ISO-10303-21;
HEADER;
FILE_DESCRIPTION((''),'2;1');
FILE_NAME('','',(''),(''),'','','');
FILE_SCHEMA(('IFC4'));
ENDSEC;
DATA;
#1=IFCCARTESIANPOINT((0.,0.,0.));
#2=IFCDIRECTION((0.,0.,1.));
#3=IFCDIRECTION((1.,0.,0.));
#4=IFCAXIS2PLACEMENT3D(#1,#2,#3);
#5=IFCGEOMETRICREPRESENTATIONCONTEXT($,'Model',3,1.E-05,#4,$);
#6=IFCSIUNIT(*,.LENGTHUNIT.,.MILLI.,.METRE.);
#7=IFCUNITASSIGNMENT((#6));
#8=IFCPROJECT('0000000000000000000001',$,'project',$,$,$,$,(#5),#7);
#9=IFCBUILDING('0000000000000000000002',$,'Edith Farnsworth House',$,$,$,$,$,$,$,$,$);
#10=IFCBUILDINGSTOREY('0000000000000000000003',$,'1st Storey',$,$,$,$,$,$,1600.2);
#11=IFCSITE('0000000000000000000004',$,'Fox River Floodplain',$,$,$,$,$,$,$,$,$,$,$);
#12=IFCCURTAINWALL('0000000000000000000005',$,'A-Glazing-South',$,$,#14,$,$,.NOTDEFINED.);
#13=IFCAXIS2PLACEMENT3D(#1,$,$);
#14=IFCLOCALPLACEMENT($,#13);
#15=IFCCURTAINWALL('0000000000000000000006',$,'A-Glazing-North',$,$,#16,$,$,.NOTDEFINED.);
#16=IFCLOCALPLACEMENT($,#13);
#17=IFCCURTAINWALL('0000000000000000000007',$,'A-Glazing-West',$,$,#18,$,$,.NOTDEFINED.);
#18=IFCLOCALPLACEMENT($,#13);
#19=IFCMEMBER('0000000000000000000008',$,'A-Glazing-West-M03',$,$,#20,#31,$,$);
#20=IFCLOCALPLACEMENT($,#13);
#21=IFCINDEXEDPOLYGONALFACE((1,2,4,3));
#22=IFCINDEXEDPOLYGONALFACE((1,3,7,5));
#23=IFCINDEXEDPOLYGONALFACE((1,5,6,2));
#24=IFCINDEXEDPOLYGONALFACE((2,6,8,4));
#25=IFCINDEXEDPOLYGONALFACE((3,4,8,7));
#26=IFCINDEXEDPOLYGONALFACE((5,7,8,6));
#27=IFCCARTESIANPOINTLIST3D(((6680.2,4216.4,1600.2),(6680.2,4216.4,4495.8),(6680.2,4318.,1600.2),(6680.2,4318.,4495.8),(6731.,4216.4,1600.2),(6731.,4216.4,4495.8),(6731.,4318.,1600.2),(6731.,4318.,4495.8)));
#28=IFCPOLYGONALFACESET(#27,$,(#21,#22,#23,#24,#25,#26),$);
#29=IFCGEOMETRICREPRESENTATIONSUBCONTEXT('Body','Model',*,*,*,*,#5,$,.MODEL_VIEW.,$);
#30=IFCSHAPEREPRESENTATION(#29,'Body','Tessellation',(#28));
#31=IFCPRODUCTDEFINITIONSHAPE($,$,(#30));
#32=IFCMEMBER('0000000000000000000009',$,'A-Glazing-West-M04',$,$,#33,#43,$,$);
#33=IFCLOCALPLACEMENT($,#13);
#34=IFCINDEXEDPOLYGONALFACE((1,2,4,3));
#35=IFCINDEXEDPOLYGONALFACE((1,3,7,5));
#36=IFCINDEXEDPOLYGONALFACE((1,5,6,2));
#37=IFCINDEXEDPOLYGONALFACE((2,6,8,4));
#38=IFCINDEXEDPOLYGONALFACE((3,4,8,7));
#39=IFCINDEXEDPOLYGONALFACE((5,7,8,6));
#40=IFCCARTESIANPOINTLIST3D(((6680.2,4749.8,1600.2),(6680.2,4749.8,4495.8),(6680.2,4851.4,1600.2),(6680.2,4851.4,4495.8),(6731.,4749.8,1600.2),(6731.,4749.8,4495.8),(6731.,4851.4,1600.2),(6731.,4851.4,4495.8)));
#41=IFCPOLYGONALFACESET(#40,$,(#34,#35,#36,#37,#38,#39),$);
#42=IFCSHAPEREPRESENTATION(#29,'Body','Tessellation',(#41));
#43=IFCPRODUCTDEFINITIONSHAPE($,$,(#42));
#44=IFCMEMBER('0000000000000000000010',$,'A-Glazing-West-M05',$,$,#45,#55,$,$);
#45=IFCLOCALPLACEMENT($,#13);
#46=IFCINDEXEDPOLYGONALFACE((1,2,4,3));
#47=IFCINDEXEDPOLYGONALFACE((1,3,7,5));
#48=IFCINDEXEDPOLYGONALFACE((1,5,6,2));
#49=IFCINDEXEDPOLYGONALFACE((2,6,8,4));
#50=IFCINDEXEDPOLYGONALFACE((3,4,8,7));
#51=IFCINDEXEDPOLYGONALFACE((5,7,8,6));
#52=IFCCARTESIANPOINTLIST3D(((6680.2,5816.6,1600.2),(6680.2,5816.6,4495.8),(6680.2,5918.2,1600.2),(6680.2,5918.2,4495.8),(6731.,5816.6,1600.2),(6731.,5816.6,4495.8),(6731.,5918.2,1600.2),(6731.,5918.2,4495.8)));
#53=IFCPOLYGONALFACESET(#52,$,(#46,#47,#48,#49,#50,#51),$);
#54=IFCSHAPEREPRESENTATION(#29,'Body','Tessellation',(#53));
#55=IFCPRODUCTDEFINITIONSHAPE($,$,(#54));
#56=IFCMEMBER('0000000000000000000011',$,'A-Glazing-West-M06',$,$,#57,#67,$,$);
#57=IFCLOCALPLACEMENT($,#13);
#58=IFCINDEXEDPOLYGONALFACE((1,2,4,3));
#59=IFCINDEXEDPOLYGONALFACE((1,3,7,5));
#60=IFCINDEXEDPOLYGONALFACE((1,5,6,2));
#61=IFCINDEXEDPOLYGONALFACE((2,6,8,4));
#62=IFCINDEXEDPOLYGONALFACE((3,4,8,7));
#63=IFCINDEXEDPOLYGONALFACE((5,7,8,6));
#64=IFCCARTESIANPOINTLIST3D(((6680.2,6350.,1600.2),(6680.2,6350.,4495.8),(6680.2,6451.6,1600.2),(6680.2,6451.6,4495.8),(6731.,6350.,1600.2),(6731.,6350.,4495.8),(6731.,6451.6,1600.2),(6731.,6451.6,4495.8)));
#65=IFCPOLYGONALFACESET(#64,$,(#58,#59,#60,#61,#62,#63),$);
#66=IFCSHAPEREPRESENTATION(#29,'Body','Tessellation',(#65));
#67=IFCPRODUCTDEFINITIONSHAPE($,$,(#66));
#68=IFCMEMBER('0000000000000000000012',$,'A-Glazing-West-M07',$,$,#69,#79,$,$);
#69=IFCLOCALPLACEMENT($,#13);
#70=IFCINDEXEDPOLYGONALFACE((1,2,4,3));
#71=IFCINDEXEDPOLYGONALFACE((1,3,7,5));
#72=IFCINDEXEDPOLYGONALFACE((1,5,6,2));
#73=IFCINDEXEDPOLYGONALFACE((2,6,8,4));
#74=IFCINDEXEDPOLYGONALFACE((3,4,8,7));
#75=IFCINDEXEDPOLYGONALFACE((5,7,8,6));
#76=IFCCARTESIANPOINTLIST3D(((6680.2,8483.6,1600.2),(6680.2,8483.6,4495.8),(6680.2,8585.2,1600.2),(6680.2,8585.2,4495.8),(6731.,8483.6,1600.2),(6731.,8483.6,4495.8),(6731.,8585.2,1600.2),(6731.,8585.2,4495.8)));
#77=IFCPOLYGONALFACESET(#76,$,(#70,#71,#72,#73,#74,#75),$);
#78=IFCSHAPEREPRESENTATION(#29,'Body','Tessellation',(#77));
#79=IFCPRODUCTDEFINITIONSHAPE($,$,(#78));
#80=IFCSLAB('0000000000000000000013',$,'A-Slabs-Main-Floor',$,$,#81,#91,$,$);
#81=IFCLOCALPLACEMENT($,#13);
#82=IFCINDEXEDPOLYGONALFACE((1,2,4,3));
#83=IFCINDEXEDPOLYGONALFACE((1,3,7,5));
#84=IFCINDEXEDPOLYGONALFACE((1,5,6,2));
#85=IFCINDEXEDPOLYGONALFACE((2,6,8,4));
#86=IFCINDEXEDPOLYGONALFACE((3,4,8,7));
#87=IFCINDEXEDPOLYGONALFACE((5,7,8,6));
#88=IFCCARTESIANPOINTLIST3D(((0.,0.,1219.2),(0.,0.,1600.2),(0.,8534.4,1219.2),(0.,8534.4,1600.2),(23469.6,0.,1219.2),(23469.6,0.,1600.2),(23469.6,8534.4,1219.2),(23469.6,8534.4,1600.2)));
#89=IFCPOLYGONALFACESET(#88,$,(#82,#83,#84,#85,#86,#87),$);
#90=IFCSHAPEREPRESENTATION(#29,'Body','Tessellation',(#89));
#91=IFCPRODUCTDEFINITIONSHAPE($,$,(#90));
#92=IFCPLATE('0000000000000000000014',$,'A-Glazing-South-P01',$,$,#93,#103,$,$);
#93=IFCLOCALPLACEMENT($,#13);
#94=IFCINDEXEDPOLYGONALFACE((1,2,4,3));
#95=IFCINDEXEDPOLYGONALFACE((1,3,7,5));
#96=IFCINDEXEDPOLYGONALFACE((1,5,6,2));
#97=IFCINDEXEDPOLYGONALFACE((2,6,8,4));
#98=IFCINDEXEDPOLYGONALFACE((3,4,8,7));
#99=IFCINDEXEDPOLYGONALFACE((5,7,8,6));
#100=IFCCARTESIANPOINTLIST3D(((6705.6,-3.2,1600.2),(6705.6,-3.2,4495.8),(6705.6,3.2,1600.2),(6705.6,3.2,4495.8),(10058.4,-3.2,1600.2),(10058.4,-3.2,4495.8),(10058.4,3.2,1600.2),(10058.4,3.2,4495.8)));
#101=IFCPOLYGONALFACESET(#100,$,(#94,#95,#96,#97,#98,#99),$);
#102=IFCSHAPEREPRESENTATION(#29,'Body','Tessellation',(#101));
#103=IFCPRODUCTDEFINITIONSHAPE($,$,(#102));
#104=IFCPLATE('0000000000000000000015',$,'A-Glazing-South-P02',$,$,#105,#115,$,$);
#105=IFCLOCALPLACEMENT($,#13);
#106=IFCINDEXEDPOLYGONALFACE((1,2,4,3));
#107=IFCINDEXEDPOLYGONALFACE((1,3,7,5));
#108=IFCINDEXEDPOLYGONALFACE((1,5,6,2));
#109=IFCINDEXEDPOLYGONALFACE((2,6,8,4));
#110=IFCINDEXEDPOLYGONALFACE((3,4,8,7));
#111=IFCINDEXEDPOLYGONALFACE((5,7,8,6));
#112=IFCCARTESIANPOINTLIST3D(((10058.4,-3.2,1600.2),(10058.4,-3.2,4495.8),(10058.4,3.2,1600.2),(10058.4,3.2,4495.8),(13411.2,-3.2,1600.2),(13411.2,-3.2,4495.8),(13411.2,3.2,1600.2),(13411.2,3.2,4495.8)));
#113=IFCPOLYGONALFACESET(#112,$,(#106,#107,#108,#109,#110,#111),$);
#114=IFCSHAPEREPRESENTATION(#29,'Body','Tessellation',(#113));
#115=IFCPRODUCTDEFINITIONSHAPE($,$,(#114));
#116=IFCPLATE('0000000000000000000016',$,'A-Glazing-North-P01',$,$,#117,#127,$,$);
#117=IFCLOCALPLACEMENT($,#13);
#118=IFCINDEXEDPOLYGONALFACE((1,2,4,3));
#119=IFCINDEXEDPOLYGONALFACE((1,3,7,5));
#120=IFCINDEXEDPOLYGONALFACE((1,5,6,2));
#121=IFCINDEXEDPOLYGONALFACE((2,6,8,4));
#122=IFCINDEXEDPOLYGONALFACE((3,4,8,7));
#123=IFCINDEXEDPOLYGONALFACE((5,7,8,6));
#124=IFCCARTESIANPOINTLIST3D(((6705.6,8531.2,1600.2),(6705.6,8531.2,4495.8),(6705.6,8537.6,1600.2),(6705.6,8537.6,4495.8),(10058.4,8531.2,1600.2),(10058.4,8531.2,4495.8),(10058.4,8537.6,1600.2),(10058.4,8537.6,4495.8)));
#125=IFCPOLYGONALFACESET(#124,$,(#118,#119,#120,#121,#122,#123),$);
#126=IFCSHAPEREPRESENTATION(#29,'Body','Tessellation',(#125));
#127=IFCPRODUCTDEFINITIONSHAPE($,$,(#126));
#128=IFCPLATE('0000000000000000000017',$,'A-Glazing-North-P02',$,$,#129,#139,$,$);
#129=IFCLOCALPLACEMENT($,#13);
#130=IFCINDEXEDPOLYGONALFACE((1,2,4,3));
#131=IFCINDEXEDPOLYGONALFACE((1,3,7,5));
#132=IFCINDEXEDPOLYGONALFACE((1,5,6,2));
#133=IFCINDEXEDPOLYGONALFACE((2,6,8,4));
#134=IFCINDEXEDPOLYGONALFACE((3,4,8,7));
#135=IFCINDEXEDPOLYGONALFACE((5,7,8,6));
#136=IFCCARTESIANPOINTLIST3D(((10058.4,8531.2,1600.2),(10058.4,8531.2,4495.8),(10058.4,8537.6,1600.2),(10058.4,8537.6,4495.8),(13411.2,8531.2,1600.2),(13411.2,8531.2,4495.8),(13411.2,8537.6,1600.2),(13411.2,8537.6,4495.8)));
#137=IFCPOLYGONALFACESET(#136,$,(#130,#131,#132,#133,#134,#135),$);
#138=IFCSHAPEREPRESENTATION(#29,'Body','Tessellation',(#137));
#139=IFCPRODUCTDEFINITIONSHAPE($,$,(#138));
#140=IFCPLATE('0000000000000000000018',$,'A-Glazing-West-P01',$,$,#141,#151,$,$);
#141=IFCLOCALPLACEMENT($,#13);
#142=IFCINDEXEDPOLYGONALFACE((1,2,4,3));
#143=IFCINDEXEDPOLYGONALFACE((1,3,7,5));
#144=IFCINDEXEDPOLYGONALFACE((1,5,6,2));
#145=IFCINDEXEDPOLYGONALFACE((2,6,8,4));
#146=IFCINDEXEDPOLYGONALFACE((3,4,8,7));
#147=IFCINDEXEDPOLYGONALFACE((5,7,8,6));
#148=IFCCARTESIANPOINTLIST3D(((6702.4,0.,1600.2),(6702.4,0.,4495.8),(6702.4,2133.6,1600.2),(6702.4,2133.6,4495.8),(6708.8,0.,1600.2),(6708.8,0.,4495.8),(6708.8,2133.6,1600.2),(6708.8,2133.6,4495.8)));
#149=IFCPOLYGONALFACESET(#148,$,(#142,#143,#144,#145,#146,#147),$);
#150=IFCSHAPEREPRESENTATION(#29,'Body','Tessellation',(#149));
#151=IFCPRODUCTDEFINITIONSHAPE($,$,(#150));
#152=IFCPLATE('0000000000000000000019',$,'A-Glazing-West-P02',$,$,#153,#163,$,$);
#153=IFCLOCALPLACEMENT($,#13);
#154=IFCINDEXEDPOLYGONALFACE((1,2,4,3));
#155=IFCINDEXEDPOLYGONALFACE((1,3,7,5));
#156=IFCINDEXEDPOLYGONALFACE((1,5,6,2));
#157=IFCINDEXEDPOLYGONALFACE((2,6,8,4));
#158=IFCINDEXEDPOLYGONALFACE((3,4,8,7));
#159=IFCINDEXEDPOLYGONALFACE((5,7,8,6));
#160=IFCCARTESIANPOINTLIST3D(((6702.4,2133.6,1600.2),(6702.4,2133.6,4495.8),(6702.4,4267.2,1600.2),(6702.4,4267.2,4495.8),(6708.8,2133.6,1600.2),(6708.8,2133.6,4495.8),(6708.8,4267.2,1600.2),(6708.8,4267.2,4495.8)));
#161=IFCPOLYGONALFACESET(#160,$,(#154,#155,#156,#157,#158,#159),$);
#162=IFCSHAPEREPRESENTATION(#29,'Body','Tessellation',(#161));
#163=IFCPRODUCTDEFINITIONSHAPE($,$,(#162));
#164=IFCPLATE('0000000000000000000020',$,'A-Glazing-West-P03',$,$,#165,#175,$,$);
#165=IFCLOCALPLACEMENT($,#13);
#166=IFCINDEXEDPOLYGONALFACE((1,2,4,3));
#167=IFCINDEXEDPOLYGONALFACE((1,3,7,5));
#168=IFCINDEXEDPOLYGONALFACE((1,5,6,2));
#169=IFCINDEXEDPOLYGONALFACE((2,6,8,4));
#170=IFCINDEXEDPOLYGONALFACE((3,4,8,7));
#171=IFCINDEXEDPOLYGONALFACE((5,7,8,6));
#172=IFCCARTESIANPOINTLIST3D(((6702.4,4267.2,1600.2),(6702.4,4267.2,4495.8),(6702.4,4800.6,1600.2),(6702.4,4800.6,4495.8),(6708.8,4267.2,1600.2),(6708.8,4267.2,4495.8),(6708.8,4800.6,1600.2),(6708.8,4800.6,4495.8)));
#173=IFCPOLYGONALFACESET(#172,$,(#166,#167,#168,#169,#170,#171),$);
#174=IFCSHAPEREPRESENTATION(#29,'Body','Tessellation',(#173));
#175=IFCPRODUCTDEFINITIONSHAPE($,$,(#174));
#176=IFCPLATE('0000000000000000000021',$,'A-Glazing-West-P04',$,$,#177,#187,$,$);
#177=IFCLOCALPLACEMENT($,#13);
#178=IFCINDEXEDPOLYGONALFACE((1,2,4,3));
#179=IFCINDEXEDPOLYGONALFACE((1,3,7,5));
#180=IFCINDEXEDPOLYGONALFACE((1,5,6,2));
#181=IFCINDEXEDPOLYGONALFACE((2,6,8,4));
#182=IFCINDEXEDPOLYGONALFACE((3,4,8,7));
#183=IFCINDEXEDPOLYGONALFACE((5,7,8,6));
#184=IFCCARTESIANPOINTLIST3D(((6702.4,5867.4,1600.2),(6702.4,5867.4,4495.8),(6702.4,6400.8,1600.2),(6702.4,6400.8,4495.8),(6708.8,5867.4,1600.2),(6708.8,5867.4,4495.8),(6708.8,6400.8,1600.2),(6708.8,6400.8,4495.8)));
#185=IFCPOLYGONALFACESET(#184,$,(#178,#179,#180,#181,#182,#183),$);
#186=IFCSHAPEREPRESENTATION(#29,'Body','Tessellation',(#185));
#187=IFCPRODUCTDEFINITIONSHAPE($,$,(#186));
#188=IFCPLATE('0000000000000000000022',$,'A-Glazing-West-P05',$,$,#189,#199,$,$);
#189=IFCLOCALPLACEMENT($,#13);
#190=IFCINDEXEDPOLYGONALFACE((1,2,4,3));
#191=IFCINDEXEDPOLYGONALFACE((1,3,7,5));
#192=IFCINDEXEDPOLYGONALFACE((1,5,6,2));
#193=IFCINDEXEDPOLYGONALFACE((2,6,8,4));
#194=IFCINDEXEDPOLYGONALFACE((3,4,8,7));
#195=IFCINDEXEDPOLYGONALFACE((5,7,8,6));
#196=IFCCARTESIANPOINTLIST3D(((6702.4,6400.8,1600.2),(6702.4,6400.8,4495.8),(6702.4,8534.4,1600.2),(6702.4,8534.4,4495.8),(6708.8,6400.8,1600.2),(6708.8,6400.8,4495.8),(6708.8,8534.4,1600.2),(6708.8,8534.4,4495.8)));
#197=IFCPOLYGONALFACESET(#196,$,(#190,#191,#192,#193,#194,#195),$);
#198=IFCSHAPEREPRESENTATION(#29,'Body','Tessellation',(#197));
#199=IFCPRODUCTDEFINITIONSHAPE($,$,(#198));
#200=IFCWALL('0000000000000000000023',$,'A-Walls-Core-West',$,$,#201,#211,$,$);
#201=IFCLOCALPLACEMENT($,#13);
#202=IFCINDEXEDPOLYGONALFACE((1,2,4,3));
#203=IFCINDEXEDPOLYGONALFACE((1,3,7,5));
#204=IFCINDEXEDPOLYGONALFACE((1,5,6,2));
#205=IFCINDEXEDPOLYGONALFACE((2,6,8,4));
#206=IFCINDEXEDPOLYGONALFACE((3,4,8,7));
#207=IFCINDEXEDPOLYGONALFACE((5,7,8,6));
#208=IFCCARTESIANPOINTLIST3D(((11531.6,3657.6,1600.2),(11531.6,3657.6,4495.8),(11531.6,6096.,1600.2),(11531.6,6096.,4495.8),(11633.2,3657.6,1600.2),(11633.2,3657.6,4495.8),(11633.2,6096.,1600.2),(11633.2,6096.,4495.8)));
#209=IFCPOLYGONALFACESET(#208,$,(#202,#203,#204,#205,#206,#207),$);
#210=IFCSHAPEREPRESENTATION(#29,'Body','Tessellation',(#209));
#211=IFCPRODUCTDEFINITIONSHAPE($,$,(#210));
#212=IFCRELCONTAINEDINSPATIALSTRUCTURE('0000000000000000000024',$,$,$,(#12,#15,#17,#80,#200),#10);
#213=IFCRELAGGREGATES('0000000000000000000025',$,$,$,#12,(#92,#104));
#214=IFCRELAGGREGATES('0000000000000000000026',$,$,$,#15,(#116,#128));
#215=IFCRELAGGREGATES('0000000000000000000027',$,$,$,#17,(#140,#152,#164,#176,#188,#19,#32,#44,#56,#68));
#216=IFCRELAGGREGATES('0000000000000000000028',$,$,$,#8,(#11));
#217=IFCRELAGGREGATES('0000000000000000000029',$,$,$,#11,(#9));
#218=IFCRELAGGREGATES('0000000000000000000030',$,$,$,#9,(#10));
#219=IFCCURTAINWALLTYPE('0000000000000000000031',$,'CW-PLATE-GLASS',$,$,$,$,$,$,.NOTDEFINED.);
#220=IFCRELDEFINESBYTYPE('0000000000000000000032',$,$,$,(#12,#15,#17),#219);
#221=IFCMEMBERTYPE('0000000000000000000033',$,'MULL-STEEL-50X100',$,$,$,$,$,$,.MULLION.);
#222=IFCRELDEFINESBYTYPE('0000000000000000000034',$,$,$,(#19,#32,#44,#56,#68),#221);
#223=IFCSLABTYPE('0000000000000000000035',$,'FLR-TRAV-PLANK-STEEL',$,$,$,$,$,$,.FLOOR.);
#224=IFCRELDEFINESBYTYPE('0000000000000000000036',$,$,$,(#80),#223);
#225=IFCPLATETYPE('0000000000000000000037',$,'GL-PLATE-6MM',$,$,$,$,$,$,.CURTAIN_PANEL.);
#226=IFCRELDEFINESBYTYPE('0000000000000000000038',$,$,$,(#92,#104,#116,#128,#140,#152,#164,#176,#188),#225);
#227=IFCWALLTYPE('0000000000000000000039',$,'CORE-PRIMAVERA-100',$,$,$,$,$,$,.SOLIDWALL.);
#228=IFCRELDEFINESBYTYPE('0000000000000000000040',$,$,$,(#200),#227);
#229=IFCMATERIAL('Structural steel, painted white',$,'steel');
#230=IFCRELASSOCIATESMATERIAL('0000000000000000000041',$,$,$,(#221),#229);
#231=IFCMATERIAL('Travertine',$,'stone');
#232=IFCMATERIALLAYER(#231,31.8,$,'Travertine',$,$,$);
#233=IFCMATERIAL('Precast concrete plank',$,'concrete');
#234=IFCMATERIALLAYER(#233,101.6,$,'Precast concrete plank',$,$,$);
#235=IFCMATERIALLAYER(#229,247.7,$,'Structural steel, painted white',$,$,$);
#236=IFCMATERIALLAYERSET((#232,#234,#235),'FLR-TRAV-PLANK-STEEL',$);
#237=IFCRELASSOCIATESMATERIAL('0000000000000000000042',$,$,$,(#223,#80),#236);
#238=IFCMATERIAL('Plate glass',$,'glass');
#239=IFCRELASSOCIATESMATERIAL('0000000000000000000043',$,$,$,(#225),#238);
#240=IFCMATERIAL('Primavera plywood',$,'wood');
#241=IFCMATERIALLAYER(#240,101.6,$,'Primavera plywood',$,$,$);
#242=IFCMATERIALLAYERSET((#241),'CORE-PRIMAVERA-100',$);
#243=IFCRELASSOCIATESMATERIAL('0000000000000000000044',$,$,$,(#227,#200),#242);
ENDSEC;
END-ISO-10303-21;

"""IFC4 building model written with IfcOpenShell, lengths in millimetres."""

from ifc_helpers import new_model, si_unit, frame, origin, origin_with_axes, place, context, subcontext, project, spatial, indexed_curve, rectangle, outline, extrude, material, layer, layer_set, layer_usage, type_object, element, aggregate, save


model = new_model("IFC4")

# Units and contexts
model_context = context("Model", 3, precision=1e-05, world=origin_with_axes())
body_context = subcontext(model_context, "Body", "Model", "MODEL_VIEW")
ifc_project = project(units=[si_unit("LENGTHUNIT", "METRE", prefix="MILLI")], contexts=[model_context])

# Site, building, storey
site = spatial("IfcSite", under=ifc_project, Name="Fox River Floodplain")
building = spatial("IfcBuilding", under=site, Name="Edith Farnsworth House")
storey = spatial("IfcBuildingStorey", under=building, Name="1st Storey", Elevation=1600.2)

# Shared definitions
ifc_material_1 = material(Name="Structural steel, painted white", Category="steel")

# Curtain walls, members
curtain_wall_type = type_object("IfcCurtainWallType", Name="CW-PLATE-GLASS", PredefinedType="NOTDEFINED")
curtain_wall_1 = element("IfcCurtainWall", 1, inside=storey, type_object=curtain_wall_type, Name="A-Glazing-South", PredefinedType="NOTDEFINED")
member_type = type_object("IfcMemberType", Name="MULL-STEEL-50X100", PredefinedType="MULLION", material=ifc_material_1)
curtain_wall_2 = element("IfcCurtainWall", 2, inside=storey, type_object=curtain_wall_type, Name="A-Glazing-North", PredefinedType="NOTDEFINED")
curtain_wall_3 = element("IfcCurtainWall", 3, inside=storey, type_object=curtain_wall_type, Name="A-Glazing-West", PredefinedType="NOTDEFINED")
member_1_placement = place(None, frame((6705.6, 4267.2, 1600.2), z_axis=(0.0, 0.0, 1.0), x_axis=(1.0, 0.0, 0.0)))
member_1 = element("IfcMember", 4, at=member_1_placement, type_object=member_type, Name="A-Glazing-West-M03", context=body_context, shape_type="SweptSolid", body=[
    extrude(rectangle(XDim=50.8, YDim=101.6), origin(), (0.0, 0.0, 1.0), 2895.6),
])
member_2_placement = place(None, frame((6705.6, 4800.6, 1600.2), z_axis=(0.0, 0.0, 1.0), x_axis=(1.0, 0.0, 0.0)))
member_2 = element("IfcMember", 5, at=member_2_placement, type_object=member_type, Name="A-Glazing-West-M04", context=body_context, shape_type="SweptSolid", body=[
    extrude(rectangle(XDim=50.8, YDim=101.6), origin(), (0.0, 0.0, 1.0), 2895.6),
])
member_3_placement = place(None, frame((6705.6, 5867.4, 1600.2), z_axis=(0.0, 0.0, 1.0), x_axis=(1.0, 0.0, 0.0)))
member_3 = element("IfcMember", 6, at=member_3_placement, type_object=member_type, Name="A-Glazing-West-M05", context=body_context, shape_type="SweptSolid", body=[
    extrude(rectangle(XDim=50.8, YDim=101.6), origin(), (0.0, 0.0, 1.0), 2895.6),
])
member_4_placement = place(None, frame((6705.6, 6400.8, 1600.2), z_axis=(0.0, 0.0, 1.0), x_axis=(1.0, 0.0, 0.0)))
member_4 = element("IfcMember", 7, at=member_4_placement, type_object=member_type, Name="A-Glazing-West-M06", context=body_context, shape_type="SweptSolid", body=[
    extrude(rectangle(XDim=50.8, YDim=101.6), origin(), (0.0, 0.0, 1.0), 2895.6),
])
member_5_placement = place(None, frame((6705.6, 8534.4, 1600.2), z_axis=(0.0, 0.0, 1.0), x_axis=(1.0, 0.0, 0.0)))
member_5 = element("IfcMember", 8, at=member_5_placement, type_object=member_type, Name="A-Glazing-West-M07", context=body_context, shape_type="SweptSolid", body=[
    extrude(rectangle(XDim=50.8, YDim=101.6), origin(), (0.0, 0.0, 1.0), 2895.6),
])

# Slab
ifc_material_2 = material(Name="Travertine", Category="stone")
ifc_layer_1 = layer(ifc_material_2, 31.8, Name="Travertine")
ifc_material_3 = material(Name="Precast concrete plank", Category="concrete")
ifc_layer_2 = layer(ifc_material_3, 101.6, Name="Precast concrete plank")
ifc_layer_3 = layer(ifc_material_1, 247.7, Name="Structural steel, painted white")
ifc_layer_set_1 = layer_set([ifc_layer_1, ifc_layer_2, ifc_layer_3], Name="FLR-TRAV-PLANK-STEEL")
ifc_layer_usage_1 = layer_usage(ifc_layer_set_1, "AXIS3", "POSITIVE", 0.0)
slab_type = type_object("IfcSlabType", Name="FLR-TRAV-PLANK-STEEL", PredefinedType="FLOOR", material=ifc_layer_set_1)
slab_placement = place(None, frame((0.0, 0.0, 1219.2), z_axis=(0.0, 0.0, 1.0), x_axis=(1.0, 0.0, 0.0)))
element("IfcSlab", 9, at=slab_placement, inside=storey, type_object=slab_type, material=ifc_layer_usage_1, Name="A-Slabs-Main-Floor", context=body_context, shape_type="SweptSolid", body=[
    extrude(outline(indexed_curve([(0.0, 0.0), (23469.6, 0.0), (23469.6, 8534.4), (0.0, 8534.4)])), None, (0.0, 0.0, 1.0), 381.0),
])

# Plates
ifc_material_4 = material(Name="Plate glass", Category="glass")
plate_type = type_object("IfcPlateType", Name="GL-PLATE-6MM", PredefinedType="CURTAIN_PANEL", material=ifc_material_4)
plate_1_placement = place(None, frame((8382.0, 0.0, 1600.2), z_axis=(0.0, 0.0, 1.0), x_axis=(1.0, 0.0, 0.0)))
plate_1 = element("IfcPlate", 10, at=plate_1_placement, type_object=plate_type, Name="A-Glazing-South-P01", context=body_context, shape_type="SweptSolid", body=[
    extrude(rectangle(XDim=3352.8, YDim=6.3), origin(), (0.0, 0.0, 1.0), 2895.6),
])
plate_2_placement = place(None, frame((11734.8, 0.0, 1600.2), z_axis=(0.0, 0.0, 1.0), x_axis=(1.0, 0.0, 0.0)))
plate_2 = element("IfcPlate", 11, at=plate_2_placement, type_object=plate_type, Name="A-Glazing-South-P02", context=body_context, shape_type="SweptSolid", body=[
    extrude(rectangle(XDim=3352.8, YDim=6.3), origin(), (0.0, 0.0, 1.0), 2895.6),
])
aggregate(curtain_wall_1, [plate_1, plate_2])
plate_3_placement = place(None, frame((8382.0, 8534.4, 1600.2), z_axis=(0.0, 0.0, 1.0), x_axis=(1.0, 0.0, 0.0)))
plate_3 = element("IfcPlate", 12, at=plate_3_placement, type_object=plate_type, Name="A-Glazing-North-P01", context=body_context, shape_type="SweptSolid", body=[
    extrude(rectangle(XDim=3352.8, YDim=6.3), origin(), (0.0, 0.0, 1.0), 2895.6),
])
plate_4_placement = place(None, frame((11734.8, 8534.4, 1600.2), z_axis=(0.0, 0.0, 1.0), x_axis=(1.0, 0.0, 0.0)))
plate_4 = element("IfcPlate", 13, at=plate_4_placement, type_object=plate_type, Name="A-Glazing-North-P02", context=body_context, shape_type="SweptSolid", body=[
    extrude(rectangle(XDim=3352.8, YDim=6.3), origin(), (0.0, 0.0, 1.0), 2895.6),
])
aggregate(curtain_wall_2, [plate_3, plate_4])
plate_5_placement = place(None, frame((6705.6, 1066.8, 1600.2), z_axis=(0.0, 0.0, 1.0), x_axis=(0.0, 1.0, 0.0)))
plate_5 = element("IfcPlate", 14, at=plate_5_placement, type_object=plate_type, Name="A-Glazing-West-P01", context=body_context, shape_type="SweptSolid", body=[
    extrude(rectangle(XDim=2133.6, YDim=6.3), origin(), (0.0, 0.0, 1.0), 2895.6),
])
plate_6_placement = place(None, frame((6705.6, 3200.4, 1600.2), z_axis=(0.0, 0.0, 1.0), x_axis=(0.0, 1.0, 0.0)))
plate_6 = element("IfcPlate", 15, at=plate_6_placement, type_object=plate_type, Name="A-Glazing-West-P02", context=body_context, shape_type="SweptSolid", body=[
    extrude(rectangle(XDim=2133.6, YDim=6.3), origin(), (0.0, 0.0, 1.0), 2895.6),
])
plate_7_placement = place(None, frame((6705.6, 4533.9, 1600.2), z_axis=(0.0, 0.0, 1.0), x_axis=(0.0, 1.0, 0.0)))
plate_7 = element("IfcPlate", 16, at=plate_7_placement, type_object=plate_type, Name="A-Glazing-West-P03", context=body_context, shape_type="SweptSolid", body=[
    extrude(rectangle(XDim=533.4, YDim=6.3), origin(), (0.0, 0.0, 1.0), 2895.6),
])
plate_8_placement = place(None, frame((6705.6, 6134.1, 1600.2), z_axis=(0.0, 0.0, 1.0), x_axis=(0.0, 1.0, 0.0)))
plate_8 = element("IfcPlate", 17, at=plate_8_placement, type_object=plate_type, Name="A-Glazing-West-P04", context=body_context, shape_type="SweptSolid", body=[
    extrude(rectangle(XDim=533.4, YDim=6.3), origin(), (0.0, 0.0, 1.0), 2895.6),
])
plate_9_placement = place(None, frame((6705.6, 7467.6, 1600.2), z_axis=(0.0, 0.0, 1.0), x_axis=(0.0, 1.0, 0.0)))
plate_9 = element("IfcPlate", 18, at=plate_9_placement, type_object=plate_type, Name="A-Glazing-West-P05", context=body_context, shape_type="SweptSolid", body=[
    extrude(rectangle(XDim=2133.6, YDim=6.3), origin(), (0.0, 0.0, 1.0), 2895.6),
])
aggregate(curtain_wall_3, [plate_5, plate_6, plate_7, plate_8, plate_9, member_1, member_2, member_3, member_4, member_5])

# Wall
ifc_material_5 = material(Name="Primavera plywood", Category="wood")
ifc_layer_4 = layer(ifc_material_5, 101.6, Name="Primavera plywood")
ifc_layer_set_2 = layer_set([ifc_layer_4], Name="CORE-PRIMAVERA-100")
ifc_layer_usage_2 = layer_usage(ifc_layer_set_2, "AXIS2", "POSITIVE", 0.0)
wall_type = type_object("IfcWallType", Name="CORE-PRIMAVERA-100", PredefinedType="SOLIDWALL", material=ifc_layer_set_2)
wall_1_placement = place(None, frame((11582.4, 4876.8, 1600.2), z_axis=(0.0, 0.0, 1.0), x_axis=(0.0, 1.0, 0.0)))
element("IfcWall", 19, at=wall_1_placement, inside=storey, type_object=wall_type, material=ifc_layer_usage_2, Name="A-Walls-Core-West", context=body_context, shape_type="SweptSolid", body=[
    extrude(rectangle(XDim=2438.4, YDim=101.6), origin(), (0.0, 0.0, 1.0), 2895.6),
])

save(model, "model.ifc")
